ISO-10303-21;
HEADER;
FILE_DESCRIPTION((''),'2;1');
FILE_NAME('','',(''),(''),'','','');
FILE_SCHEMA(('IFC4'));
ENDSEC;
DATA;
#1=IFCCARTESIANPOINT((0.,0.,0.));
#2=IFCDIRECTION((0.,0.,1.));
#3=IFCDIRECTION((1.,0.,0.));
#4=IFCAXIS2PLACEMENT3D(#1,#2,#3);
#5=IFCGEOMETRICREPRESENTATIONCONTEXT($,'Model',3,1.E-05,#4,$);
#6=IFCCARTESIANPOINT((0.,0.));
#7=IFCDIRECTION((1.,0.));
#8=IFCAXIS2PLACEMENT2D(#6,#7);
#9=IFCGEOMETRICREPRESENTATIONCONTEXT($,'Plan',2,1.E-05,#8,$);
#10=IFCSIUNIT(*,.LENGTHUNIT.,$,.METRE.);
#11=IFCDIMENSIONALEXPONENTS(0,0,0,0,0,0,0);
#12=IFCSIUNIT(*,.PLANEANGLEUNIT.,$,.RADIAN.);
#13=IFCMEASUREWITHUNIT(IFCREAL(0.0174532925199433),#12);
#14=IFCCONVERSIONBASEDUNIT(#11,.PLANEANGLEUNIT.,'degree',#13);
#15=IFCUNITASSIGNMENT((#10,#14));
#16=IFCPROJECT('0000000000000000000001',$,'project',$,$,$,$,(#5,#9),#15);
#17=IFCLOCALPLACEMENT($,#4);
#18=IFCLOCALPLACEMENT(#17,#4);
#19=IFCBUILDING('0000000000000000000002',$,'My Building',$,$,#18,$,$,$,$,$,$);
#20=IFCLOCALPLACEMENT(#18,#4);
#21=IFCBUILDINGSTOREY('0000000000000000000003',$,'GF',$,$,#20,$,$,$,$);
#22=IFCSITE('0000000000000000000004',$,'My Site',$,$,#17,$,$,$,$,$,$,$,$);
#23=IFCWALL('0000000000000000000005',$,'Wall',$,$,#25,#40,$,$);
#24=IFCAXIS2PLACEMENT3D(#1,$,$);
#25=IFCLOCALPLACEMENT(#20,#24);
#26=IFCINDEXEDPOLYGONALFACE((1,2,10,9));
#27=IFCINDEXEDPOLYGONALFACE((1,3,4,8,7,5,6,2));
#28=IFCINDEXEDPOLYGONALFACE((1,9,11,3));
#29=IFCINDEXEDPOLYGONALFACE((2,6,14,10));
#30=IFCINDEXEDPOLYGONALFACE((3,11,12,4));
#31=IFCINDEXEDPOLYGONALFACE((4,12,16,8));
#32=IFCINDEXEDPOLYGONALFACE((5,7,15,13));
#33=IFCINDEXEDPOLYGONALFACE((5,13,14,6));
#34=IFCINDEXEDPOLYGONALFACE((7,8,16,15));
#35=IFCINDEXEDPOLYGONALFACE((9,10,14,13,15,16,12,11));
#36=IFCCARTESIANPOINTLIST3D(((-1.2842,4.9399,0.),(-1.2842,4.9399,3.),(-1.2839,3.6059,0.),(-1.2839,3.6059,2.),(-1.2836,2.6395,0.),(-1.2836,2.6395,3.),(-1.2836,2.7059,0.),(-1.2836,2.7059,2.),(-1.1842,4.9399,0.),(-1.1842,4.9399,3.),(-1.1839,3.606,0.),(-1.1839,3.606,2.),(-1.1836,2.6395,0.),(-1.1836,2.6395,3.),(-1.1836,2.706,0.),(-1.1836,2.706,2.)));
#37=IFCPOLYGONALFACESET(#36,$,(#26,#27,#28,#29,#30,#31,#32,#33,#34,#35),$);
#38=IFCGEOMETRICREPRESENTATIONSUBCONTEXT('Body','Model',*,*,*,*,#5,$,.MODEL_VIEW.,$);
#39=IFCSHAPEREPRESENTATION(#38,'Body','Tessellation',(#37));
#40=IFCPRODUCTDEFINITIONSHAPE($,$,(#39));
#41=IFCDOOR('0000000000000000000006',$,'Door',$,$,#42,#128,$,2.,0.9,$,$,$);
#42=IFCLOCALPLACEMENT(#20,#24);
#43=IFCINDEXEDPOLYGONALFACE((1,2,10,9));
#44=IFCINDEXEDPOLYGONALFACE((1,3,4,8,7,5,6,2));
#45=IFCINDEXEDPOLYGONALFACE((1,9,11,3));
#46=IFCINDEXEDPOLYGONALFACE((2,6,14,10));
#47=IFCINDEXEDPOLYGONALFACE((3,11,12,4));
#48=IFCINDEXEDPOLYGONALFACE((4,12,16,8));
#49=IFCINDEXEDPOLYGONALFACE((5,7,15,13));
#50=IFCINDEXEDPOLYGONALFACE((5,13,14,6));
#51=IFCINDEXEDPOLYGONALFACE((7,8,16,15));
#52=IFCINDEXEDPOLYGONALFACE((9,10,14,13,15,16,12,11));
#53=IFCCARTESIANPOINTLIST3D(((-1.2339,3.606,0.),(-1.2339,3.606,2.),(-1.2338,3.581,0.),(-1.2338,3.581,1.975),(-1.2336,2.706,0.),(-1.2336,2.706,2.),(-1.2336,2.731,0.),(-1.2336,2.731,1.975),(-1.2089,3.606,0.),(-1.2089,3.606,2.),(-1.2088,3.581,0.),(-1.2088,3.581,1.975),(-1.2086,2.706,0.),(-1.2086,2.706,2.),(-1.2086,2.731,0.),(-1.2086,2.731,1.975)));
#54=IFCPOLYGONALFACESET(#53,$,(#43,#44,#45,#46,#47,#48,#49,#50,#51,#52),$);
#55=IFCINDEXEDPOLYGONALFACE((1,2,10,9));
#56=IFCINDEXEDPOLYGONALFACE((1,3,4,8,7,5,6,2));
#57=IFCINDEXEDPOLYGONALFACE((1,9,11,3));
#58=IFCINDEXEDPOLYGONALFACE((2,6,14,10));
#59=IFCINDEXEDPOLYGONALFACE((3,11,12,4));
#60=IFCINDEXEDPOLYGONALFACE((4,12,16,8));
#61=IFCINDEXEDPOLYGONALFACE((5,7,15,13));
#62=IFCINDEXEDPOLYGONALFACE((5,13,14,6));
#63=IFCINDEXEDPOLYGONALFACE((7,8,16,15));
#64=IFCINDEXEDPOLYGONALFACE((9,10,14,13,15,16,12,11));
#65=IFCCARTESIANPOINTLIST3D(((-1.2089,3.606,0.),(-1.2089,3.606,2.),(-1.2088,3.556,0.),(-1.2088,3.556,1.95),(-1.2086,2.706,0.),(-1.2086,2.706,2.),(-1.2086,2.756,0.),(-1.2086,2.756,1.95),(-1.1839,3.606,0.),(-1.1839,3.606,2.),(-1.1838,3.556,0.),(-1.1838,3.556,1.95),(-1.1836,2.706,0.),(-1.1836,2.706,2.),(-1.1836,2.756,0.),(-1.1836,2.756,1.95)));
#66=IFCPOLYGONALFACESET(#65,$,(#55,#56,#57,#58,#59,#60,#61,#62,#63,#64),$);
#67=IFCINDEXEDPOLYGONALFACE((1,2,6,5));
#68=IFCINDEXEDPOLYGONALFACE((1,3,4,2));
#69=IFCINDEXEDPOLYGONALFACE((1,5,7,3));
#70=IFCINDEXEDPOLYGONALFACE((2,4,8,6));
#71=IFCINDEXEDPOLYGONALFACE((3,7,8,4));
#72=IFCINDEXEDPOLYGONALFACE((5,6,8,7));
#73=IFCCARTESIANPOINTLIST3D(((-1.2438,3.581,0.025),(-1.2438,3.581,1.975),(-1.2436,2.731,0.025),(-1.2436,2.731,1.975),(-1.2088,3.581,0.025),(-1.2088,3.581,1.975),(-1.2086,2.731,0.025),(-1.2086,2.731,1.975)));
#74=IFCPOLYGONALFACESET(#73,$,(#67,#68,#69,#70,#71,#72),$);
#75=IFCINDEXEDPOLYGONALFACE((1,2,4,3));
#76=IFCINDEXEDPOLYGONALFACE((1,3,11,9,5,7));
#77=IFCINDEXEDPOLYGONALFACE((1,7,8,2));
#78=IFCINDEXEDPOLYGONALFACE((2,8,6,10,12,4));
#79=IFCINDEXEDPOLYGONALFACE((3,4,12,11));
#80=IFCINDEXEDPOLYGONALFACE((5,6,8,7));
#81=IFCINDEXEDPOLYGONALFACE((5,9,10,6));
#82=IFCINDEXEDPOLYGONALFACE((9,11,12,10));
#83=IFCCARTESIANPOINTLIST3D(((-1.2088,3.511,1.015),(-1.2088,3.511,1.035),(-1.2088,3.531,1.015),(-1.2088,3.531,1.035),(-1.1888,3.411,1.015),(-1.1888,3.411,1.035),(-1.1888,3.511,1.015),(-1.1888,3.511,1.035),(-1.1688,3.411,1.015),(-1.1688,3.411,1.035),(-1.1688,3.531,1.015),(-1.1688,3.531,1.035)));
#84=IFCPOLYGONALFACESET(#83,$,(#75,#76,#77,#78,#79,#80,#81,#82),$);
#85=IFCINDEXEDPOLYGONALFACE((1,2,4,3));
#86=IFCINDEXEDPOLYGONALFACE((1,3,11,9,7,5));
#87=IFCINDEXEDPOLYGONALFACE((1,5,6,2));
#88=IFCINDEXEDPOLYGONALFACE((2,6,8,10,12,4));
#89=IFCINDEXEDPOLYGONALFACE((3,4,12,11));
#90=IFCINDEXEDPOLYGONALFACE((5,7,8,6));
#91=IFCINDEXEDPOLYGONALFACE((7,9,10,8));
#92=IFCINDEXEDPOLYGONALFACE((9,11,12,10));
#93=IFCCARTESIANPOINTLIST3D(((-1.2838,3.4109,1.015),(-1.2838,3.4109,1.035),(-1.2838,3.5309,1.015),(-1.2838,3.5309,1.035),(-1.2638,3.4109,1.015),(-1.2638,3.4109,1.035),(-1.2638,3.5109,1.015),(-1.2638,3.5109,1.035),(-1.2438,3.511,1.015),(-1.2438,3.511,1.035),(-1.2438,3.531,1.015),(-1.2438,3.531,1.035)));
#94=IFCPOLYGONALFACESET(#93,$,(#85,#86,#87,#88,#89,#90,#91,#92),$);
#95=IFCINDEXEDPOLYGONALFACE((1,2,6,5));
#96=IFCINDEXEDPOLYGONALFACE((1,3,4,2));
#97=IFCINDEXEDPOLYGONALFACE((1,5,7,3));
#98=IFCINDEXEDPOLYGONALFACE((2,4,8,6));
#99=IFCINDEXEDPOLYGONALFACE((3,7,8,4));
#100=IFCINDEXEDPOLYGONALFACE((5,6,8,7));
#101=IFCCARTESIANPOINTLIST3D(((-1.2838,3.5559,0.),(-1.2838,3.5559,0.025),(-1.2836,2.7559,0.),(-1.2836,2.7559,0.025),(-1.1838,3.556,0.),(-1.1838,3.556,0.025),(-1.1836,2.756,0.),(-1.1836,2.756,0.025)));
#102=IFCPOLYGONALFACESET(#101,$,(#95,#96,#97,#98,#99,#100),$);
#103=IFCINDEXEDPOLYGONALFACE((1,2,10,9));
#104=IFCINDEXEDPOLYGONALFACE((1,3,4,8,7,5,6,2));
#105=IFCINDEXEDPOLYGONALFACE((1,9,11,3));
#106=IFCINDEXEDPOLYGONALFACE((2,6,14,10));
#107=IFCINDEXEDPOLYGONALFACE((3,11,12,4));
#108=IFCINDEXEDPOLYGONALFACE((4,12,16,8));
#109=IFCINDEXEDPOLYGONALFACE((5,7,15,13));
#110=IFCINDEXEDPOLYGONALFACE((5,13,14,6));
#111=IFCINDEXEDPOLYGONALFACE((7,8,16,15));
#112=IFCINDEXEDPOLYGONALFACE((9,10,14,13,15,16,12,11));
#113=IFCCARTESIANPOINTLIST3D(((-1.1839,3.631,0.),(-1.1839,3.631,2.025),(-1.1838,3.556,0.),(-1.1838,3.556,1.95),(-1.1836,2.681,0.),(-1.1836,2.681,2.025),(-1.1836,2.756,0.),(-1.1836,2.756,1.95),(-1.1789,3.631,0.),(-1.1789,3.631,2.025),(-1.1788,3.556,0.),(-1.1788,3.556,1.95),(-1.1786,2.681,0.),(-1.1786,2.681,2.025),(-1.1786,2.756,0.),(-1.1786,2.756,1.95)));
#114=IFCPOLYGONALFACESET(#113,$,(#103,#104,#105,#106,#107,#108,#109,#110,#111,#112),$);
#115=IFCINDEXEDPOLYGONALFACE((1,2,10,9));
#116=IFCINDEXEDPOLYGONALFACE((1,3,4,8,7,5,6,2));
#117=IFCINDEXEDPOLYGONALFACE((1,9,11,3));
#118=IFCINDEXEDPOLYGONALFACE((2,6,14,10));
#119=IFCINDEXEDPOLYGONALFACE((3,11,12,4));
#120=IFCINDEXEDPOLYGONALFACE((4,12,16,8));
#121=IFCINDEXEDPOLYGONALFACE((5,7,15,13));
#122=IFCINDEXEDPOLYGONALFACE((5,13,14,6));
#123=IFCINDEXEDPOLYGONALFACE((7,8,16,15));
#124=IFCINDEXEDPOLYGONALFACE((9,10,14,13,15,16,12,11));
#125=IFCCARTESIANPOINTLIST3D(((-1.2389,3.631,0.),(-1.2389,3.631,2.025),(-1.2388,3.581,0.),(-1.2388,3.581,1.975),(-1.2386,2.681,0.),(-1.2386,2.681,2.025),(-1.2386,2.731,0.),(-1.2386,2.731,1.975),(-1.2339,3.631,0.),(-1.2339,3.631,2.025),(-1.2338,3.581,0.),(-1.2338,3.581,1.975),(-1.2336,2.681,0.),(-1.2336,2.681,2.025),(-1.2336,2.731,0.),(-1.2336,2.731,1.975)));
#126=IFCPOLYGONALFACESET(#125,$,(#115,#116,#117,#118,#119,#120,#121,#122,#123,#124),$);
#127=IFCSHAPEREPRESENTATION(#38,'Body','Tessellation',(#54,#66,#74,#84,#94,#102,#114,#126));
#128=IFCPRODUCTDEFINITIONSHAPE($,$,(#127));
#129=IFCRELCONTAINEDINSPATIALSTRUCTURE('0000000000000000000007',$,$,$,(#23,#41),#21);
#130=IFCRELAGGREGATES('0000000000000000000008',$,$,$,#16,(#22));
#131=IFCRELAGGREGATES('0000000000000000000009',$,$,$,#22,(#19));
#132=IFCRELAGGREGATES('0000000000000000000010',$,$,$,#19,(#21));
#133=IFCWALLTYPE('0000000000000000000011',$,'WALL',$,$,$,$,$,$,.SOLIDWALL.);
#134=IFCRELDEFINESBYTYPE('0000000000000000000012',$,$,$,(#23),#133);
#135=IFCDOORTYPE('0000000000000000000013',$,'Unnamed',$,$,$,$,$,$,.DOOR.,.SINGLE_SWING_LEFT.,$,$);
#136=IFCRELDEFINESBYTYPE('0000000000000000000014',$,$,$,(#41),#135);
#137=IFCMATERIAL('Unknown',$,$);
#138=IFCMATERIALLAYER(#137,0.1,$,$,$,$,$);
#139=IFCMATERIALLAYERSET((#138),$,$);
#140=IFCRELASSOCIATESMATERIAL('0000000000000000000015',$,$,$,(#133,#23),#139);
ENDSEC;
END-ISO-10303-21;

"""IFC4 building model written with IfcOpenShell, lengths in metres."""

from ifc_helpers import new_model, entity, si_unit, converted_unit, frame, origin_with_axes, origin_2d_with_axis, place, context, subcontext, project, spatial, line, indexed_curve, outline, extrude, shape, source, transform, mapped, material, layer, layer_set, layer_usage, type_object, type_shapes, element, fill, save


model = new_model("IFC4")

# Units and contexts
model_context = context("Model", 3, precision=1e-05, world=origin_with_axes())
plan_context = context("Plan", 2, precision=1e-05, world=origin_2d_with_axis())
body_context_1 = subcontext(model_context, "Body", "Model", "MODEL_VIEW")
body_context_2 = subcontext(plan_context, "Body", "Plan", "PLAN_VIEW")
ifc_project = project(units=[si_unit("LENGTHUNIT", "METRE"), converted_unit("PLANEANGLEUNIT", "degree", entity("IfcReal", 0.0174532925199433), si_unit("PLANEANGLEUNIT", "RADIAN"), dimensions=[0, 0, 0, 0, 0, 0, 0])], contexts=[model_context, plan_context])

# Site, building, storey
site_placement = place(None, origin_with_axes())
site = spatial("IfcSite", under=ifc_project, at=site_placement, Name="My Site")
building_placement = place(site_placement, origin_with_axes())
building = spatial("IfcBuilding", under=site, at=building_placement, Name="My Building")
storey_placement = place(building_placement, origin_with_axes())
storey = spatial("IfcBuildingStorey", under=building, at=storey_placement, Name="GF")

# Shared definitions
ifc_material_1 = material(Name="Unknown")
ifc_layer_1 = layer(ifc_material_1, 0.1)
ifc_layer_set_1 = layer_set([ifc_layer_1])
wall_type = type_object("IfcWallType", Name="WALL", PredefinedType="SOLIDWALL", material=ifc_layer_set_1)

# Wall, opening, door
ifc_layer_usage_1 = layer_usage(ifc_layer_set_1, "AXIS2", "POSITIVE", 0.0)
wall_1_placement = place(storey_placement, frame((-1.1836, 2.6395, 0.0), z_axis=(0.0, 0.0, 1.0), x_axis=(-0.000265, 1.0, 0.0)))
wall_1 = element("IfcWall", 1, at=wall_1_placement, inside=storey, type_object=wall_type, material=ifc_layer_usage_1, Name="Wall", context=body_context_1, shape_type="SweptSolid", body=[
    extrude(outline(indexed_curve([(0.0, 0.0), (0.0, 0.1), (2.3004, 0.1), (2.3004, 0.0)], segments=[line(1, 2, 3, 4, 1)])), origin_with_axes(), (0.0, 0.0, 1.0), 3.0),
])
shared_shape_1 = source(origin_with_axes(), body_context_1, "Body", "SweptSolid", [
    extrude(outline(indexed_curve([(0.0, 0.0), (0.9, 0.0), (0.9, 2.0), (0.0, 2.0)], segments=[line(1, 2, 3, 4, 1)])), frame((0.0, -0.6, 0.0), z_axis=(0.0, -1.0, 0.0), x_axis=(1.0, 0.0, 0.0)), (0.0, 0.0, -1.0), 1.2),
])
opening_1_placement = place(wall_1_placement, frame((0.0664, 0.0, 0.0), z_axis=(0.0, 0.0, 1.0), x_axis=(1.0, 0.0, 0.0)))
opening_1 = element("IfcOpeningElement", 2, at=opening_1_placement, cuts=wall_1, PredefinedType="OPENING", context=body_context_1, shape_type="MappedRepresentation", body=[
    mapped(shared_shape_1, transform((0.0, 0.0, 0.0), x_axis=(1.0, 0.0, 0.0), y_axis=(0.0, 1.0, 0.0), z_axis=(0.0, 0.0, 1.0), scale=1.0)),
])
door_type = type_object("IfcDoorType", Name="Unnamed", OperationType="SINGLE_SWING_LEFT", PredefinedType="DOOR")
shared_shape_2 = source(origin_with_axes(), body_context_1, "Body", "SweptSolid", [
    extrude(outline(indexed_curve([(0.0, 0.0), (0.0, 2.0), (0.9, 2.0), (0.9, 0.0), (0.875, 0.0), (0.875, 1.975), (0.025, 1.975), (0.025, 0.0)], segments=[line(1, 2, 3, 4, 5, 6, 7, 8, 1)])), frame((0.0, 0.025, 0.0), z_axis=(0.0, -1.0, 0.0), x_axis=(1.0, 0.0, 0.0)), (0.0, 0.0, -1.0), 0.025),
    extrude(outline(indexed_curve([(0.0, 0.0), (0.0, 2.0), (0.9, 2.0), (0.9, 0.0), (0.85, 0.0), (0.85, 1.95), (0.05, 1.95), (0.05, 0.0)], segments=[line(1, 2, 3, 4, 5, 6, 7, 8, 1)])), frame((0.0, 0.0, 0.0), z_axis=(0.0, -1.0, 0.0), x_axis=(1.0, 0.0, 0.0)), (0.0, 0.0, -1.0), 0.025),
    extrude(outline(indexed_curve([(0.0, 0.0), (0.85, 0.0), (0.85, 0.035), (0.0, 0.035)], segments=[line(1, 2, 3, 4, 1)])), frame((0.025, 0.025, 0.025), z_axis=(0.0, 0.0, 1.0), x_axis=(1.0, 0.0, 0.0)), (0.0, 0.0, 1.0), 1.95),
    extrude(outline(indexed_curve([(0.0, 0.0), (0.0, -0.04), (-0.12, -0.04), (-0.12, -0.02), (-0.02, -0.02), (-0.02, 0.0)], segments=[line(1, 2, 3, 4, 5, 6, 1)])), frame((0.825, 0.025, 1.015), z_axis=(0.0, 0.0, 1.0), x_axis=(1.0, 0.0, 0.0)), (0.0, 0.0, 1.0), 0.02),
    extrude(outline(indexed_curve([(0.0, 0.0), (0.0, 0.04), (-0.12, 0.04), (-0.12, 0.02), (-0.02, 0.02), (-0.02, 0.0)], segments=[line(1, 2, 3, 4, 5, 6, 1)])), frame((0.825, 0.06, 1.015), z_axis=(0.0, 0.0, 1.0), x_axis=(1.0, 0.0, 0.0)), (0.0, 0.0, 1.0), 0.02),
    extrude(outline(indexed_curve([(0.0, 0.0), (0.8, 0.0), (0.8, 0.1), (0.0, 0.1)], segments=[line(1, 2, 3, 4, 1)])), frame((0.05, 0.0, 0.0), z_axis=(0.0, 0.0, 1.0), x_axis=(1.0, 0.0, 0.0)), (0.0, 0.0, 1.0), 0.025),
    extrude(outline(indexed_curve([(0.0, 0.0), (0.0, 2.025), (0.95, 2.025), (0.95, 0.0), (0.875, 0.0), (0.875, 1.95), (0.075, 1.95), (0.075, 0.0)], segments=[line(1, 2, 3, 4, 5, 6, 7, 8, 1)])), frame((-0.025, -0.005, 0.0), z_axis=(0.0, -1.0, 0.0), x_axis=(1.0, 0.0, 0.0)), (0.0, 0.0, -1.0), 0.005),
    extrude(outline(indexed_curve([(0.0, 0.0), (0.0, 2.025), (0.95, 2.025), (0.95, 0.0), (0.9, 0.0), (0.9, 1.975), (0.05, 1.975), (0.05, 0.0)], segments=[line(1, 2, 3, 4, 5, 6, 7, 8, 1)])), frame((-0.025, 0.05, 0.0), z_axis=(0.0, -1.0, 0.0), x_axis=(1.0, 0.0, 0.0)), (0.0, 0.0, -1.0), 0.005),
])
shared_shape_3 = source(origin_with_axes(), body_context_2, "Body", "Curve2D", [
    entity("IfcIndexedPolyCurve", entity("IfcCartesianPointList2D", [[0.0, 0.0], [0.0, 0.05], [0.025, 0.05], [0.025, 0.025], [0.05, 0.025], [0.05, 0.0]]), [entity("IfcLineIndex", [1, 2, 3, 4, 5, 6, 1])]),
    entity("IfcIndexedPolyCurve", entity("IfcCartesianPointList2D", [[0.9, 0.0], [0.9, 0.05], [0.875, 0.05], [0.875, 0.025], [0.85, 0.025], [0.85, 0.0]]), [entity("IfcLineIndex", [1, 2, 3, 4, 5, 6, 1])]),
    entity("IfcTrimmedCurve", entity("IfcEllipse", entity("IfcAxis2Placement2D", entity("IfcCartesianPoint", [0.06, 0.05]), entity("IfcDirection", [1.0, 0.0])), 0.815, 0.85), [entity("IfcCartesianPoint", [0.875, 0.05])], [entity("IfcCartesianPoint", [0.06, 0.9])], True, "CARTESIAN"),
    entity("IfcIndexedPolyCurve", entity("IfcCartesianPointList2D", [[0.025, 0.05], [0.06, 0.05], [0.06, 0.9], [0.025, 0.9]]), [entity("IfcLineIndex", [1, 2, 3, 4, 1])]),
])
type_shapes(door_type, [shared_shape_2, shared_shape_3])
door_1_placement = place(opening_1_placement, frame((0.0, 0.0, 0.0), z_axis=(0.0, 0.0, 1.0), x_axis=(1.0, 0.0, 0.0)))
door_1 = element("IfcDoor", 3, at=door_1_placement, inside=storey, type_object=door_type, Name="Door", OverallHeight=2.0, OverallWidth=0.9, shapes=[
    shape(body_context_1, "Body", "MappedRepresentation", [mapped(shared_shape_2, transform((0.0, 0.0, 0.0), x_axis=(1.0, 0.0, 0.0), y_axis=(0.0, 1.0, 0.0), z_axis=(0.0, 0.0, 1.0), scale=1.0))]),
    shape(body_context_2, "Body", "MappedRepresentation", [mapped(shared_shape_3, transform((0.0, 0.0, 0.0), x_axis=(1.0, 0.0, 0.0), y_axis=(0.0, 1.0, 0.0), z_axis=(0.0, 0.0, 1.0), scale=1.0))]),
])
fill(opening_1, door_1)

save(model, "model.ifc")
